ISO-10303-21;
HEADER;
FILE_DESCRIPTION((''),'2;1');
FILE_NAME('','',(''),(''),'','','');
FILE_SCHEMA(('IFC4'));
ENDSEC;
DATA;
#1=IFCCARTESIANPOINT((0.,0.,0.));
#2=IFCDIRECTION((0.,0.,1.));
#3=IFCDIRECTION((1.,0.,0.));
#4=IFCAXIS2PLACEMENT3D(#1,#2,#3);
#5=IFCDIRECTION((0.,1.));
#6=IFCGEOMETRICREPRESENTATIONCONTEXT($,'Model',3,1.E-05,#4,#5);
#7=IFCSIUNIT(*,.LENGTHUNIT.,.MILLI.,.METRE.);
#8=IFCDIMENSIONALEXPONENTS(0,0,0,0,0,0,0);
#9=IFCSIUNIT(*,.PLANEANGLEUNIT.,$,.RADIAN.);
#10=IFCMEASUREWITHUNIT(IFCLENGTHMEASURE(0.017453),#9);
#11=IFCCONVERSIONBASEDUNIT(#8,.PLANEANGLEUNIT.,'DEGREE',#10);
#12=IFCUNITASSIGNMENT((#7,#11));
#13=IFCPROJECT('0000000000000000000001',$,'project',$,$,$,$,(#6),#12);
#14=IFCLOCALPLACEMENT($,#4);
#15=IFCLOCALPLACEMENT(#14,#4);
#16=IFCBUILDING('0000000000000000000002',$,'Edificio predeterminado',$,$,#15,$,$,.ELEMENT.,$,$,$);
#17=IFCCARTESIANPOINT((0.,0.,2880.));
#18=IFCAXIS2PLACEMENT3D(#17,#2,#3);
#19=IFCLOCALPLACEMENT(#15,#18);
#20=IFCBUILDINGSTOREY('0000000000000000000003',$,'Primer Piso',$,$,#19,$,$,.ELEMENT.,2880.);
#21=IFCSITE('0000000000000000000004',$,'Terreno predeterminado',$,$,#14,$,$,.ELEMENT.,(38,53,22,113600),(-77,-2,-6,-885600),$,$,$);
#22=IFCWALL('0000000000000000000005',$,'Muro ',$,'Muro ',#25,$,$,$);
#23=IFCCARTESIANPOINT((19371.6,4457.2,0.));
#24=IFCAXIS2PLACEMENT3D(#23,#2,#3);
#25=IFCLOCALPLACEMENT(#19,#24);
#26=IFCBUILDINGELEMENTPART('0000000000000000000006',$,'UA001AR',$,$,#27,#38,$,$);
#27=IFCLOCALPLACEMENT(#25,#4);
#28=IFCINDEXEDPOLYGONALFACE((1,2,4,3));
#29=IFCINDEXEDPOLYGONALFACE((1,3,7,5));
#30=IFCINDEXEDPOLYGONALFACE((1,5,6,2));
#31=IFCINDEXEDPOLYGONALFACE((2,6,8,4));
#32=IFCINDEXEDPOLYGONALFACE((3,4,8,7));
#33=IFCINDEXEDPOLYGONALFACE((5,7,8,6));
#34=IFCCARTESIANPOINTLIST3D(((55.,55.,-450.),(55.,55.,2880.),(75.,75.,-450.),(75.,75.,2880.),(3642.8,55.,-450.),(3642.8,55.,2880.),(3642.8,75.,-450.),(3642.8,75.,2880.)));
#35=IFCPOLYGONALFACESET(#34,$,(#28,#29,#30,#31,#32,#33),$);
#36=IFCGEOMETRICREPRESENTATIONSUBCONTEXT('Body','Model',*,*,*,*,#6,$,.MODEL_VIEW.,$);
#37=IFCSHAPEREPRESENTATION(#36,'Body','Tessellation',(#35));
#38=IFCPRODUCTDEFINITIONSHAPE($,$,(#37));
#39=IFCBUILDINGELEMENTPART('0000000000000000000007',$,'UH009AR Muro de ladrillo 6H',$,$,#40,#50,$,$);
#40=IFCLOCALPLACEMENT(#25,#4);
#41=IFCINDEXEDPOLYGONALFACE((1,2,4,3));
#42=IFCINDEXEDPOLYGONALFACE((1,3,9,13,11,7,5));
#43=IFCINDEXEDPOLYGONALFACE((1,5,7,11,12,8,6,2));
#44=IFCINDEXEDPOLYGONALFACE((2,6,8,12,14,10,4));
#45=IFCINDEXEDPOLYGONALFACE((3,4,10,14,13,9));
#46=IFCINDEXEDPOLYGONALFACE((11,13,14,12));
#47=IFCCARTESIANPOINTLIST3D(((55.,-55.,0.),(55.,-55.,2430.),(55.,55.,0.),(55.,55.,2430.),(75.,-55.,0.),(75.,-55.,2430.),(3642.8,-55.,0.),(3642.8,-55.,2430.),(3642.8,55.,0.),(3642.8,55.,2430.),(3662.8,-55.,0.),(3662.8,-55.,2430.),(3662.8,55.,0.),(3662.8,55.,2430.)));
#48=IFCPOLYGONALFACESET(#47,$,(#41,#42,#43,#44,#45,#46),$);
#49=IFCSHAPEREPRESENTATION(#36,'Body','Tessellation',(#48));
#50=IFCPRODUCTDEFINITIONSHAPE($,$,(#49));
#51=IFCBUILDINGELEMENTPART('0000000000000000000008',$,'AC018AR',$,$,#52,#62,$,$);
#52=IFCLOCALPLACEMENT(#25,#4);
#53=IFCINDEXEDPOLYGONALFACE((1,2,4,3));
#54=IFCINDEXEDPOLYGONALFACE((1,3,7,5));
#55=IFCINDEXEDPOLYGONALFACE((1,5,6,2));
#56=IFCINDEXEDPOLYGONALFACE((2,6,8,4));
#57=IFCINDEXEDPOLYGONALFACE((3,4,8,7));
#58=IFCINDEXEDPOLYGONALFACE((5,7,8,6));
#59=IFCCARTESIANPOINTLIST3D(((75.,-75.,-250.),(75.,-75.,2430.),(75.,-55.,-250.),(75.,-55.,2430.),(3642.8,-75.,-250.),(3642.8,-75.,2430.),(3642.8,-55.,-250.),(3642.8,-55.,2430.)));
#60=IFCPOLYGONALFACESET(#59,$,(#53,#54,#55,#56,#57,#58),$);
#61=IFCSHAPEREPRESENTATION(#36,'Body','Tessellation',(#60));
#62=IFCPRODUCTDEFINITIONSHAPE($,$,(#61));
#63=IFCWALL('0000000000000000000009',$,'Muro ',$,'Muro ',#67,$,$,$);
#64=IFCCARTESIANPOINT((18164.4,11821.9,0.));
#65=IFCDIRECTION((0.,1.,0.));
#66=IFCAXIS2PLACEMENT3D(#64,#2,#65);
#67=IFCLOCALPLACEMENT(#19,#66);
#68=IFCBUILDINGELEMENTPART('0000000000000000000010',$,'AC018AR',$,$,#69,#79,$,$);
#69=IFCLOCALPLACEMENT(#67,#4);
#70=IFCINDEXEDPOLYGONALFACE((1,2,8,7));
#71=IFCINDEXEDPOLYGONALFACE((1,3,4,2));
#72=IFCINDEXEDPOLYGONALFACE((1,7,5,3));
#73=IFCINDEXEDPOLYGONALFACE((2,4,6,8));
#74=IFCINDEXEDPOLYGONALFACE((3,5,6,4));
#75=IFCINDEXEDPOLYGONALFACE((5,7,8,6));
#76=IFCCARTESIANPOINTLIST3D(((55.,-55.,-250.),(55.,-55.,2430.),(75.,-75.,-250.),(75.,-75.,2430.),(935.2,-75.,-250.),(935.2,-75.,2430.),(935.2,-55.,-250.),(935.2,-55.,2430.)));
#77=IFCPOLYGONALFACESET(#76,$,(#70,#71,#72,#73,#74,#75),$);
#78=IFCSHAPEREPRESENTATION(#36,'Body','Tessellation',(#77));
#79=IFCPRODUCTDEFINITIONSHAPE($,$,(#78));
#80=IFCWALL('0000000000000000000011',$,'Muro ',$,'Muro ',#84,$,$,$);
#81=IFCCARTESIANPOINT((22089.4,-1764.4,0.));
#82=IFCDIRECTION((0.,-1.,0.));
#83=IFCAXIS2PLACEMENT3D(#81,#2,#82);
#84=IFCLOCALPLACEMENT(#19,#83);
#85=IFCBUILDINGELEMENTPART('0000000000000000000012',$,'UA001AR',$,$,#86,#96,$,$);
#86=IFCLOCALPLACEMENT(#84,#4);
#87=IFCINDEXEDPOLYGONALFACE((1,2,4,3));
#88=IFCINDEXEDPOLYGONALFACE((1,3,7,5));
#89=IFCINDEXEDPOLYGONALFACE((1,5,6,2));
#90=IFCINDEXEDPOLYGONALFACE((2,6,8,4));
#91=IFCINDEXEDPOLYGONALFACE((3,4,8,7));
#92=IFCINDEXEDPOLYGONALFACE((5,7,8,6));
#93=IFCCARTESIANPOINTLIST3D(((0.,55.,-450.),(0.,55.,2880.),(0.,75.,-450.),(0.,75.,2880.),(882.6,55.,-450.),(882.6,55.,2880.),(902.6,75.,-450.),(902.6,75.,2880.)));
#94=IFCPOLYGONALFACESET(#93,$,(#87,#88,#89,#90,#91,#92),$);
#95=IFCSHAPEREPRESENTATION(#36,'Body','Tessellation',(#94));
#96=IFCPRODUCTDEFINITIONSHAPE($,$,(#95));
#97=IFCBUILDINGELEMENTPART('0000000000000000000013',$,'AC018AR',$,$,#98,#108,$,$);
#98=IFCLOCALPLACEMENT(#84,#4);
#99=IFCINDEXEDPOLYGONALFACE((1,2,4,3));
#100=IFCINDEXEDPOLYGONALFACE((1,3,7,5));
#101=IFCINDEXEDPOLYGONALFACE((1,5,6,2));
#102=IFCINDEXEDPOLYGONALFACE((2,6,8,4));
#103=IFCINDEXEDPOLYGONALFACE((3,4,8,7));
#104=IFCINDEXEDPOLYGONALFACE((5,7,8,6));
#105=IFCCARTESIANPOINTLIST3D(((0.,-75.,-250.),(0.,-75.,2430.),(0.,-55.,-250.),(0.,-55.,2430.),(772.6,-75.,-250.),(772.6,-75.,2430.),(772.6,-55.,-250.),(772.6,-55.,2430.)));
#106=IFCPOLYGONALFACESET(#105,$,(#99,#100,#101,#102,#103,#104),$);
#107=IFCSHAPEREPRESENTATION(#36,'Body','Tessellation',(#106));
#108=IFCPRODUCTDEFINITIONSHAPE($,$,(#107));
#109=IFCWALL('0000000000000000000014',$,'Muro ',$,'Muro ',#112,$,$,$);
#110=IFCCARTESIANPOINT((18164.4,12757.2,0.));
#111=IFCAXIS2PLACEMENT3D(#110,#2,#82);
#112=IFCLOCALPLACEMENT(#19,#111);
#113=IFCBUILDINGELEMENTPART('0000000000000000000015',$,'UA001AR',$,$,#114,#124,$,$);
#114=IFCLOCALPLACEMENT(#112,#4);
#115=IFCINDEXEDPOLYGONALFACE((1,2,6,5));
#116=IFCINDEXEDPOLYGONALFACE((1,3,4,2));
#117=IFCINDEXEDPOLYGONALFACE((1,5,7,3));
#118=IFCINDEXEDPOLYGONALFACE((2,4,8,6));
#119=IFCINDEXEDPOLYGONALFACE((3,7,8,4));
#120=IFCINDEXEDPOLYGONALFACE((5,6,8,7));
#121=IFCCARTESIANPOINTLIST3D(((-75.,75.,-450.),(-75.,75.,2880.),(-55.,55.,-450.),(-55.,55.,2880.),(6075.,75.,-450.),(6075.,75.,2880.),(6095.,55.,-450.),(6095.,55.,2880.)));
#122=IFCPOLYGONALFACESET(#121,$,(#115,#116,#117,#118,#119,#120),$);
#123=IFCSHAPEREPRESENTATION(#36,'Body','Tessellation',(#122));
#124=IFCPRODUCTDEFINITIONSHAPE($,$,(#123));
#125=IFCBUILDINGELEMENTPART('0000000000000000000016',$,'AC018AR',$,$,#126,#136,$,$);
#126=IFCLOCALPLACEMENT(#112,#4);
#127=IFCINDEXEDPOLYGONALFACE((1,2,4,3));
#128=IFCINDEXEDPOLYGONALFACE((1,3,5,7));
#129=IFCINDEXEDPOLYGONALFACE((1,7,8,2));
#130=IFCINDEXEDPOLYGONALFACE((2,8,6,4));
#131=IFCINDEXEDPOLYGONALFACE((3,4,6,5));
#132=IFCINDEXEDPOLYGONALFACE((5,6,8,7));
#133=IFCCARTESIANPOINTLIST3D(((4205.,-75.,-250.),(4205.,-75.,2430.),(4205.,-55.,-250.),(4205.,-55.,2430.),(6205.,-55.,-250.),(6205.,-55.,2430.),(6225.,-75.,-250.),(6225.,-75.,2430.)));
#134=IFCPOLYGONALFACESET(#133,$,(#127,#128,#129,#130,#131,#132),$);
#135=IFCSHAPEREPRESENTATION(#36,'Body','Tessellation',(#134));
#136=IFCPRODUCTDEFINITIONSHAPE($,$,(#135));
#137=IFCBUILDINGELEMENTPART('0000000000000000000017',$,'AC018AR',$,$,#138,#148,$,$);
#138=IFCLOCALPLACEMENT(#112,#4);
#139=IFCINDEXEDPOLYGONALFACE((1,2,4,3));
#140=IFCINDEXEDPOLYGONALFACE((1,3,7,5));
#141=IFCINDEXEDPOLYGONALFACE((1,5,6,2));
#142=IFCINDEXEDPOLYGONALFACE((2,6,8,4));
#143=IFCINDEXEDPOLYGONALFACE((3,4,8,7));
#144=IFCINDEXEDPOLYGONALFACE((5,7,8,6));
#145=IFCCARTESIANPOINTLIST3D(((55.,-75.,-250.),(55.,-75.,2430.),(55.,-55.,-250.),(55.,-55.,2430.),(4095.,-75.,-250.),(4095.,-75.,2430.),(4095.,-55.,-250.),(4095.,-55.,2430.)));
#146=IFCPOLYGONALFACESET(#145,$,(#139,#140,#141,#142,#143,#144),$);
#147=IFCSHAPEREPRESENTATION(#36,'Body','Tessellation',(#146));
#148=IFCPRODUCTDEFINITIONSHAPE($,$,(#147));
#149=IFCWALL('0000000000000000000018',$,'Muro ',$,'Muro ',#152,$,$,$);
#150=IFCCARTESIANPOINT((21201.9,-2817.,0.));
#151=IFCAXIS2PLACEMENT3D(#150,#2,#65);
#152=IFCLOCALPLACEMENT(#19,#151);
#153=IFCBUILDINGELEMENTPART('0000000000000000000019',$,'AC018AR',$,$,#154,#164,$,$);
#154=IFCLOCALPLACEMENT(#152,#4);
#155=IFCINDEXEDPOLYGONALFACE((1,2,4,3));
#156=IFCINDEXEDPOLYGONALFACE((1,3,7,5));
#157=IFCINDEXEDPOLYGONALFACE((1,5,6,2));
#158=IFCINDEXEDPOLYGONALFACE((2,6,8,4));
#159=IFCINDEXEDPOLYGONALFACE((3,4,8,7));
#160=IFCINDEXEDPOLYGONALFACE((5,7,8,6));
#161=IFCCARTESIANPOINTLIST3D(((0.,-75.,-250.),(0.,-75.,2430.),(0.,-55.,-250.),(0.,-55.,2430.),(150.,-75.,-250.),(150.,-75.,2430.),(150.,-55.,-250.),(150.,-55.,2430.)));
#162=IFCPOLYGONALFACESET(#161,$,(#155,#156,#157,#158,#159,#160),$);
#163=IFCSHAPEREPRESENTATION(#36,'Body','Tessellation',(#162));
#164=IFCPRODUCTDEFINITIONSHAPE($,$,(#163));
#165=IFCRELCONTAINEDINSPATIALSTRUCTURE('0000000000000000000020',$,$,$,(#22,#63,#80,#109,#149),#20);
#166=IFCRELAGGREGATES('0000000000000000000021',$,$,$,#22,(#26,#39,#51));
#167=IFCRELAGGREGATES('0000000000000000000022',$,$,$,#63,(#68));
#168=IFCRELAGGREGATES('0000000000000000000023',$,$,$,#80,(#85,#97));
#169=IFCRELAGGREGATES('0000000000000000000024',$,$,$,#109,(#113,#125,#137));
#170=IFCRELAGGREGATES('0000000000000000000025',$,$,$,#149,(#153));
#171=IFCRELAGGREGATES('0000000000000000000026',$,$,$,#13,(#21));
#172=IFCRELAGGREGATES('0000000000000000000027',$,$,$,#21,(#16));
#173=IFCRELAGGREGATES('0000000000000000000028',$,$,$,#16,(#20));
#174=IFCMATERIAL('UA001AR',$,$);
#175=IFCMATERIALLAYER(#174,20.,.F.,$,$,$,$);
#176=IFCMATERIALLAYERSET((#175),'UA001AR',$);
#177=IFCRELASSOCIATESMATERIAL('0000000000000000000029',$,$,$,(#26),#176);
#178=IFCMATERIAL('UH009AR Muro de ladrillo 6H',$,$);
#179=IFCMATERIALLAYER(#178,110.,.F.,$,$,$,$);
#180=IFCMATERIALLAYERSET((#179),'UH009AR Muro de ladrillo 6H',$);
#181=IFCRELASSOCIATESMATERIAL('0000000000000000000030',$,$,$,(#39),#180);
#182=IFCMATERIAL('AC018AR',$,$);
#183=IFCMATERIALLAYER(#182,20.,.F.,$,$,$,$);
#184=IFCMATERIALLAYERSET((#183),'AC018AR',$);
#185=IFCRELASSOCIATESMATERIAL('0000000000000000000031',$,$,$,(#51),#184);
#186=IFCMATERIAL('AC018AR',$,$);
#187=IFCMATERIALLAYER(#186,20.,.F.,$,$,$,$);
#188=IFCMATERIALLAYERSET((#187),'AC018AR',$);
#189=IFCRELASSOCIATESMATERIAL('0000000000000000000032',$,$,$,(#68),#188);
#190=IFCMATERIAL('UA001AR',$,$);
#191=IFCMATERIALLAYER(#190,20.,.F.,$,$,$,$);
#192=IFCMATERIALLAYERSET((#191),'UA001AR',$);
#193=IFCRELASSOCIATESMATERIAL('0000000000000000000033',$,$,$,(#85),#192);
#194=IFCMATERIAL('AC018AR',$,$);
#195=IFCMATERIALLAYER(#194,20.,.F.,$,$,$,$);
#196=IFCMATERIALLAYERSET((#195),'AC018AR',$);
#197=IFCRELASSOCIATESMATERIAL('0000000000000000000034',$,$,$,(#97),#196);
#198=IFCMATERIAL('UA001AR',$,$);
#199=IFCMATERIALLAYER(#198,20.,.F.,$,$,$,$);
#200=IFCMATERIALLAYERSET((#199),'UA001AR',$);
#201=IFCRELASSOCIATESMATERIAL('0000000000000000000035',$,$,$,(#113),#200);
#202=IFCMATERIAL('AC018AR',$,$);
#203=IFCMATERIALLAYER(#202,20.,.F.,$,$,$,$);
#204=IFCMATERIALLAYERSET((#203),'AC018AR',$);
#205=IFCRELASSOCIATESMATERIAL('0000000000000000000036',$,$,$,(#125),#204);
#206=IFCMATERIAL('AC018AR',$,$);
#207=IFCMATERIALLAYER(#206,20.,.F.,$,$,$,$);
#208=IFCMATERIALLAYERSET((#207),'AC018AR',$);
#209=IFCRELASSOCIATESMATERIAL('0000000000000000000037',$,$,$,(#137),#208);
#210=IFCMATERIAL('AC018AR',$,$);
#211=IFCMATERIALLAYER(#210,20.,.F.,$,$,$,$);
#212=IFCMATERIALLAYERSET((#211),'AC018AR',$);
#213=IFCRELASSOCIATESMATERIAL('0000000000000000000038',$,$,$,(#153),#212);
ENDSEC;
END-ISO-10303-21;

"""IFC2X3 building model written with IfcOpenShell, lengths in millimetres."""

from ifc_helpers import new_model, entity, si_unit, converted_unit, direction, frame, origin_with_axes, place, context, subcontext, project, spatial, polyline, outline, extrude, clip, bounded_halfspace, material, layer, layer_set, layer_usage, element, aggregate, save


model = new_model("IFC2X3")

# Units and contexts
model_context = context("Model", 3, precision=1e-05, world=origin_with_axes(), true_north=direction((0.0, 1.0)))
body_context = subcontext(model_context, "Body", "Model", "MODEL_VIEW")
ifc_project = project(units=[si_unit("LENGTHUNIT", "METRE", prefix="MILLI"), converted_unit("PLANEANGLEUNIT", "DEGREE", entity("IfcLengthMeasure", 0.017453), si_unit("PLANEANGLEUNIT", "RADIAN"), dimensions=[0, 0, 0, 0, 0, 0, 0])], contexts=[model_context])

# Site, building, storey
site_placement = place(None, origin_with_axes())
site = spatial("IfcSite", under=ifc_project, at=site_placement, Name="Terreno predeterminado", CompositionType="ELEMENT", RefLatitude=(38, 53, 22, 113600), RefLongitude=(-77, -2, -6, -885600))
building_placement = place(site_placement, origin_with_axes())
building = spatial("IfcBuilding", under=site, at=building_placement, Name="Edificio predeterminado", CompositionType="ELEMENT")
storey_placement = place(building_placement, frame((0.0, 0.0, 2880.0), z_axis=(0.0, 0.0, 1.0), x_axis=(1.0, 0.0, 0.0)))
storey = spatial("IfcBuildingStorey", under=building, at=storey_placement, Name="Primer Piso", CompositionType="ELEMENT", Elevation=2880.0)

# Walls, building element parts
wall_1_placement = place(storey_placement, frame((19371.6, 4457.2, 0.0), z_axis=(0.0, 0.0, 1.0), x_axis=(1.0, 0.0, 0.0)))
wall_1 = element("IfcWall", 1, at=wall_1_placement, inside=storey, Name="Muro ", ObjectType="Muro ")
ifc_material_1 = material(Name="UA001AR")
ifc_layer_1 = layer(ifc_material_1, 20.0, ventilated=False)
ifc_layer_set_1 = layer_set([ifc_layer_1], Name="UA001AR")
ifc_layer_usage_1 = layer_usage(ifc_layer_set_1, "AXIS2", "NEGATIVE", -75.0)
building_element_part_1_placement = place(wall_1_placement, origin_with_axes())
building_element_part_1 = element("IfcBuildingElementPart", 2, at=building_element_part_1_placement, material=ifc_layer_usage_1, Name="UA001AR", context=body_context, shape_type="SweptSolid", body=[
    extrude(outline(polyline([(3642.8, 75.0), (3642.8, 55.0), (55.0, 55.0), (75.0, 75.0), (3642.8, 75.0)])), frame((0.0, 0.0, -450.0), z_axis=(0.0, 0.0, 1.0), x_axis=(1.0, 0.0, 0.0)), (0.0, 0.0, 1.0), 3330.0),
])
ifc_material_2 = material(Name="UH009AR Muro de ladrillo 6H")
ifc_layer_2 = layer(ifc_material_2, 110.0, ventilated=False)
ifc_layer_set_2 = layer_set([ifc_layer_2], Name="UH009AR Muro de ladrillo 6H")
ifc_layer_usage_2 = layer_usage(ifc_layer_set_2, "AXIS2", "NEGATIVE", -55.0)
building_element_part_2_placement = place(wall_1_placement, origin_with_axes())
building_element_part_2 = element("IfcBuildingElementPart", 3, at=building_element_part_2_placement, material=ifc_layer_usage_2, Name="UH009AR Muro de ladrillo 6H", context=body_context, shape_type="SweptSolid", body=[
    extrude(outline(polyline([(3662.8, 55.0), (3662.8, -55.0), (3642.8, -55.0), (75.0, -55.0), (55.0, -55.0), (55.0, 55.0), (3642.8, 55.0), (3662.8, 55.0)])), origin_with_axes(), (0.0, 0.0, 1.0), 2430.0),
])
ifc_material_3 = material(Name="AC018AR")
ifc_layer_3 = layer(ifc_material_3, 20.0, ventilated=False)
ifc_layer_set_3 = layer_set([ifc_layer_3], Name="AC018AR")
ifc_layer_usage_3 = layer_usage(ifc_layer_set_3, "AXIS2", "NEGATIVE", 55.0)
building_element_part_3_placement = place(wall_1_placement, origin_with_axes())
building_element_part_3 = element("IfcBuildingElementPart", 4, at=building_element_part_3_placement, material=ifc_layer_usage_3, Name="AC018AR", context=body_context, shape_type="SweptSolid", body=[
    extrude(outline(polyline([(3642.8, -55.0), (3642.8, -75.0), (75.0, -75.0), (75.0, -55.0), (3642.8, -55.0)])), frame((0.0, 0.0, -250.0), z_axis=(0.0, 0.0, 1.0), x_axis=(1.0, 0.0, 0.0)), (0.0, 0.0, 1.0), 2680.0),
])
aggregate(wall_1, [building_element_part_1, building_element_part_2, building_element_part_3])
wall_2_placement = place(storey_placement, frame((18164.4, 11821.9, 0.0), z_axis=(0.0, 0.0, 1.0), x_axis=(0.0, 1.0, 0.0)))
wall_2 = element("IfcWall", 5, at=wall_2_placement, inside=storey, Name="Muro ", ObjectType="Muro ")
ifc_material_4 = material(Name="AC018AR")
ifc_layer_4 = layer(ifc_material_4, 20.0, ventilated=False)
ifc_layer_set_4 = layer_set([ifc_layer_4], Name="AC018AR")
ifc_layer_usage_4 = layer_usage(ifc_layer_set_4, "AXIS2", "NEGATIVE", 55.0)
building_element_part_4_placement = place(wall_2_placement, origin_with_axes())
building_element_part_4 = element("IfcBuildingElementPart", 6, at=building_element_part_4_placement, material=ifc_layer_usage_4, Name="AC018AR", context=body_context, shape_type="SweptSolid", body=[
    extrude(outline(polyline([(935.2, -55.0), (935.2, -75.0), (75.0, -75.0), (55.0, -55.0), (935.2, -55.0)])), frame((0.0, 0.0, -250.0), z_axis=(0.0, 0.0, 1.0), x_axis=(1.0, 0.0, 0.0)), (0.0, 0.0, 1.0), 2680.0),
])
aggregate(wall_2, [building_element_part_4])
wall_3_placement = place(storey_placement, frame((22089.4, -1764.4, 0.0), z_axis=(0.0, 0.0, 1.0), x_axis=(0.0, -1.0, 0.0)))
wall_3 = element("IfcWall", 7, at=wall_3_placement, inside=storey, Name="Muro ", ObjectType="Muro ")
ifc_material_5 = material(Name="UA001AR")
ifc_layer_5 = layer(ifc_material_5, 20.0, ventilated=False)
ifc_layer_set_5 = layer_set([ifc_layer_5], Name="UA001AR")
ifc_layer_usage_5 = layer_usage(ifc_layer_set_5, "AXIS2", "NEGATIVE", -75.0)
building_element_part_5_placement = place(wall_3_placement, origin_with_axes())
building_element_part_5 = element("IfcBuildingElementPart", 8, at=building_element_part_5_placement, material=ifc_layer_usage_5, Name="UA001AR", context=body_context, shape_type="SweptSolid", body=[
    extrude(outline(polyline([(902.6, 75.0), (882.6, 55.0), (0.0, 55.0), (0.0, 75.0), (902.6, 75.0)])), frame((0.0, 0.0, -450.0), z_axis=(0.0, 0.0, 1.0), x_axis=(1.0, 0.0, 0.0)), (0.0, 0.0, 1.0), 3330.0),
])
ifc_material_6 = material(Name="AC018AR")
ifc_layer_6 = layer(ifc_material_6, 20.0, ventilated=False)
ifc_layer_set_6 = layer_set([ifc_layer_6], Name="AC018AR")
ifc_layer_usage_6 = layer_usage(ifc_layer_set_6, "AXIS2", "NEGATIVE", 55.0)
building_element_part_6_placement = place(wall_3_placement, origin_with_axes())
building_element_part_6 = element("IfcBuildingElementPart", 9, at=building_element_part_6_placement, material=ifc_layer_usage_6, Name="AC018AR", context=body_context, shape_type="SweptSolid", body=[
    extrude(outline(polyline([(772.6, -55.0), (772.6, -75.0), (0.0, -75.0), (0.0, -55.0), (772.6, -55.0)])), frame((0.0, 0.0, -250.0), z_axis=(0.0, 0.0, 1.0), x_axis=(1.0, 0.0, 0.0)), (0.0, 0.0, 1.0), 2680.0),
])
aggregate(wall_3, [building_element_part_5, building_element_part_6])
wall_4_placement = place(storey_placement, frame((18164.4, 12757.2, 0.0), z_axis=(0.0, 0.0, 1.0), x_axis=(0.0, -1.0, 0.0)))
wall_4 = element("IfcWall", 10, at=wall_4_placement, inside=storey, Name="Muro ", ObjectType="Muro ")
ifc_material_7 = material(Name="UA001AR")
ifc_layer_7 = layer(ifc_material_7, 20.0, ventilated=False)
ifc_layer_set_7 = layer_set([ifc_layer_7], Name="UA001AR")
ifc_layer_usage_7 = layer_usage(ifc_layer_set_7, "AXIS2", "NEGATIVE", -75.0)
building_element_part_7_placement = place(wall_4_placement, origin_with_axes())
building_element_part_7 = element("IfcBuildingElementPart", 11, at=building_element_part_7_placement, material=ifc_layer_usage_7, Name="UA001AR", context=body_context, shape_type="SweptSolid", body=[
    extrude(outline(polyline([(6075.0, 75.0), (6095.0, 55.0), (-55.0, 55.0), (-75.0, 75.0), (6075.0, 75.0)])), frame((0.0, 0.0, -450.0), z_axis=(0.0, 0.0, 1.0), x_axis=(1.0, 0.0, 0.0)), (0.0, 0.0, 1.0), 3330.0),
])
ifc_material_8 = material(Name="AC018AR")
ifc_layer_8 = layer(ifc_material_8, 20.0, ventilated=False)
ifc_layer_set_8 = layer_set([ifc_layer_8], Name="AC018AR")
ifc_layer_usage_8 = layer_usage(ifc_layer_set_8, "AXIS2", "NEGATIVE", 55.0)
building_element_part_8_placement = place(wall_4_placement, origin_with_axes())
building_element_part_8 = element("IfcBuildingElementPart", 12, at=building_element_part_8_placement, material=ifc_layer_usage_8, Name="AC018AR", context=body_context, shape_type="SweptSolid", body=[
    extrude(outline(polyline([(6205.0, -55.0), (6225.0, -75.0), (4205.0, -75.0), (4205.0, -55.0), (6205.0, -55.0)])), frame((0.0, 0.0, -250.0), z_axis=(0.0, 0.0, 1.0), x_axis=(1.0, 0.0, 0.0)), (0.0, 0.0, 1.0), 2680.0),
])
ifc_material_9 = material(Name="AC018AR")
ifc_layer_9 = layer(ifc_material_9, 20.0, ventilated=False)
ifc_layer_set_9 = layer_set([ifc_layer_9], Name="AC018AR")
ifc_layer_usage_9 = layer_usage(ifc_layer_set_9, "AXIS2", "NEGATIVE", 55.0)
building_element_part_9_placement = place(wall_4_placement, origin_with_axes())
building_element_part_9 = element("IfcBuildingElementPart", 13, at=building_element_part_9_placement, material=ifc_layer_usage_9, Name="AC018AR", context=body_context, shape_type="SweptSolid", body=[
    extrude(outline(polyline([(4095.0, -55.0), (4095.0, -75.0), (55.0, -75.0), (55.0, -55.0), (4095.0, -55.0)])), frame((0.0, 0.0, -250.0), z_axis=(0.0, 0.0, 1.0), x_axis=(1.0, 0.0, 0.0)), (0.0, 0.0, 1.0), 2680.0),
])
aggregate(wall_4, [building_element_part_7, building_element_part_8, building_element_part_9])
wall_5_placement = place(storey_placement, frame((21201.9, -2817.0, 0.0), z_axis=(0.0, 0.0, 1.0), x_axis=(0.0, 1.0, 0.0)))
wall_5 = element("IfcWall", 14, at=wall_5_placement, inside=storey, Name="Muro ", ObjectType="Muro ")
ifc_material_10 = material(Name="AC018AR")
ifc_layer_10 = layer(ifc_material_10, 20.0, ventilated=False)
ifc_layer_set_10 = layer_set([ifc_layer_10], Name="AC018AR")
ifc_layer_usage_10 = layer_usage(ifc_layer_set_10, "AXIS2", "NEGATIVE", 55.0)
building_element_part_10_placement = place(wall_5_placement, origin_with_axes())
building_element_part_10 = element("IfcBuildingElementPart", 15, at=building_element_part_10_placement, material=ifc_layer_usage_10, Name="AC018AR", context=body_context, shape_type="Clipping", body=[
    clip(clip(extrude(outline(polyline([(150.0, -55.0), (150.0, -75.0), (0.0, -75.0), (0.0, -55.0), (150.0, -55.0)])), frame((0.0, 0.0, -250.0), z_axis=(0.0, 0.0, 1.0), x_axis=(1.0, 0.0, 0.0)), (0.0, 0.0, 1.0), 2680.0), bounded_halfspace(frame((0.0, 0.0, -250.0), z_axis=(0.0, 0.0, 1.0), x_axis=(1.0, 0.0, 0.0)), True, origin_with_axes(), polyline([(-150.0, -150.0), (375.0, -150.0), (375.0, 150.0), (-150.0, 150.0), (-150.0, -150.0)]))), bounded_halfspace(frame((0.0, 0.0, 2430.0), z_axis=(0.0, 0.0, 1.0), x_axis=(1.0, 0.0, 0.0)), False, origin_with_axes(), polyline([(-150.0, -150.0), (375.0, -150.0), (375.0, 150.0), (-150.0, 150.0), (-150.0, -150.0)]))),
])
aggregate(wall_5, [building_element_part_10])

save(model, "model.ifc")
